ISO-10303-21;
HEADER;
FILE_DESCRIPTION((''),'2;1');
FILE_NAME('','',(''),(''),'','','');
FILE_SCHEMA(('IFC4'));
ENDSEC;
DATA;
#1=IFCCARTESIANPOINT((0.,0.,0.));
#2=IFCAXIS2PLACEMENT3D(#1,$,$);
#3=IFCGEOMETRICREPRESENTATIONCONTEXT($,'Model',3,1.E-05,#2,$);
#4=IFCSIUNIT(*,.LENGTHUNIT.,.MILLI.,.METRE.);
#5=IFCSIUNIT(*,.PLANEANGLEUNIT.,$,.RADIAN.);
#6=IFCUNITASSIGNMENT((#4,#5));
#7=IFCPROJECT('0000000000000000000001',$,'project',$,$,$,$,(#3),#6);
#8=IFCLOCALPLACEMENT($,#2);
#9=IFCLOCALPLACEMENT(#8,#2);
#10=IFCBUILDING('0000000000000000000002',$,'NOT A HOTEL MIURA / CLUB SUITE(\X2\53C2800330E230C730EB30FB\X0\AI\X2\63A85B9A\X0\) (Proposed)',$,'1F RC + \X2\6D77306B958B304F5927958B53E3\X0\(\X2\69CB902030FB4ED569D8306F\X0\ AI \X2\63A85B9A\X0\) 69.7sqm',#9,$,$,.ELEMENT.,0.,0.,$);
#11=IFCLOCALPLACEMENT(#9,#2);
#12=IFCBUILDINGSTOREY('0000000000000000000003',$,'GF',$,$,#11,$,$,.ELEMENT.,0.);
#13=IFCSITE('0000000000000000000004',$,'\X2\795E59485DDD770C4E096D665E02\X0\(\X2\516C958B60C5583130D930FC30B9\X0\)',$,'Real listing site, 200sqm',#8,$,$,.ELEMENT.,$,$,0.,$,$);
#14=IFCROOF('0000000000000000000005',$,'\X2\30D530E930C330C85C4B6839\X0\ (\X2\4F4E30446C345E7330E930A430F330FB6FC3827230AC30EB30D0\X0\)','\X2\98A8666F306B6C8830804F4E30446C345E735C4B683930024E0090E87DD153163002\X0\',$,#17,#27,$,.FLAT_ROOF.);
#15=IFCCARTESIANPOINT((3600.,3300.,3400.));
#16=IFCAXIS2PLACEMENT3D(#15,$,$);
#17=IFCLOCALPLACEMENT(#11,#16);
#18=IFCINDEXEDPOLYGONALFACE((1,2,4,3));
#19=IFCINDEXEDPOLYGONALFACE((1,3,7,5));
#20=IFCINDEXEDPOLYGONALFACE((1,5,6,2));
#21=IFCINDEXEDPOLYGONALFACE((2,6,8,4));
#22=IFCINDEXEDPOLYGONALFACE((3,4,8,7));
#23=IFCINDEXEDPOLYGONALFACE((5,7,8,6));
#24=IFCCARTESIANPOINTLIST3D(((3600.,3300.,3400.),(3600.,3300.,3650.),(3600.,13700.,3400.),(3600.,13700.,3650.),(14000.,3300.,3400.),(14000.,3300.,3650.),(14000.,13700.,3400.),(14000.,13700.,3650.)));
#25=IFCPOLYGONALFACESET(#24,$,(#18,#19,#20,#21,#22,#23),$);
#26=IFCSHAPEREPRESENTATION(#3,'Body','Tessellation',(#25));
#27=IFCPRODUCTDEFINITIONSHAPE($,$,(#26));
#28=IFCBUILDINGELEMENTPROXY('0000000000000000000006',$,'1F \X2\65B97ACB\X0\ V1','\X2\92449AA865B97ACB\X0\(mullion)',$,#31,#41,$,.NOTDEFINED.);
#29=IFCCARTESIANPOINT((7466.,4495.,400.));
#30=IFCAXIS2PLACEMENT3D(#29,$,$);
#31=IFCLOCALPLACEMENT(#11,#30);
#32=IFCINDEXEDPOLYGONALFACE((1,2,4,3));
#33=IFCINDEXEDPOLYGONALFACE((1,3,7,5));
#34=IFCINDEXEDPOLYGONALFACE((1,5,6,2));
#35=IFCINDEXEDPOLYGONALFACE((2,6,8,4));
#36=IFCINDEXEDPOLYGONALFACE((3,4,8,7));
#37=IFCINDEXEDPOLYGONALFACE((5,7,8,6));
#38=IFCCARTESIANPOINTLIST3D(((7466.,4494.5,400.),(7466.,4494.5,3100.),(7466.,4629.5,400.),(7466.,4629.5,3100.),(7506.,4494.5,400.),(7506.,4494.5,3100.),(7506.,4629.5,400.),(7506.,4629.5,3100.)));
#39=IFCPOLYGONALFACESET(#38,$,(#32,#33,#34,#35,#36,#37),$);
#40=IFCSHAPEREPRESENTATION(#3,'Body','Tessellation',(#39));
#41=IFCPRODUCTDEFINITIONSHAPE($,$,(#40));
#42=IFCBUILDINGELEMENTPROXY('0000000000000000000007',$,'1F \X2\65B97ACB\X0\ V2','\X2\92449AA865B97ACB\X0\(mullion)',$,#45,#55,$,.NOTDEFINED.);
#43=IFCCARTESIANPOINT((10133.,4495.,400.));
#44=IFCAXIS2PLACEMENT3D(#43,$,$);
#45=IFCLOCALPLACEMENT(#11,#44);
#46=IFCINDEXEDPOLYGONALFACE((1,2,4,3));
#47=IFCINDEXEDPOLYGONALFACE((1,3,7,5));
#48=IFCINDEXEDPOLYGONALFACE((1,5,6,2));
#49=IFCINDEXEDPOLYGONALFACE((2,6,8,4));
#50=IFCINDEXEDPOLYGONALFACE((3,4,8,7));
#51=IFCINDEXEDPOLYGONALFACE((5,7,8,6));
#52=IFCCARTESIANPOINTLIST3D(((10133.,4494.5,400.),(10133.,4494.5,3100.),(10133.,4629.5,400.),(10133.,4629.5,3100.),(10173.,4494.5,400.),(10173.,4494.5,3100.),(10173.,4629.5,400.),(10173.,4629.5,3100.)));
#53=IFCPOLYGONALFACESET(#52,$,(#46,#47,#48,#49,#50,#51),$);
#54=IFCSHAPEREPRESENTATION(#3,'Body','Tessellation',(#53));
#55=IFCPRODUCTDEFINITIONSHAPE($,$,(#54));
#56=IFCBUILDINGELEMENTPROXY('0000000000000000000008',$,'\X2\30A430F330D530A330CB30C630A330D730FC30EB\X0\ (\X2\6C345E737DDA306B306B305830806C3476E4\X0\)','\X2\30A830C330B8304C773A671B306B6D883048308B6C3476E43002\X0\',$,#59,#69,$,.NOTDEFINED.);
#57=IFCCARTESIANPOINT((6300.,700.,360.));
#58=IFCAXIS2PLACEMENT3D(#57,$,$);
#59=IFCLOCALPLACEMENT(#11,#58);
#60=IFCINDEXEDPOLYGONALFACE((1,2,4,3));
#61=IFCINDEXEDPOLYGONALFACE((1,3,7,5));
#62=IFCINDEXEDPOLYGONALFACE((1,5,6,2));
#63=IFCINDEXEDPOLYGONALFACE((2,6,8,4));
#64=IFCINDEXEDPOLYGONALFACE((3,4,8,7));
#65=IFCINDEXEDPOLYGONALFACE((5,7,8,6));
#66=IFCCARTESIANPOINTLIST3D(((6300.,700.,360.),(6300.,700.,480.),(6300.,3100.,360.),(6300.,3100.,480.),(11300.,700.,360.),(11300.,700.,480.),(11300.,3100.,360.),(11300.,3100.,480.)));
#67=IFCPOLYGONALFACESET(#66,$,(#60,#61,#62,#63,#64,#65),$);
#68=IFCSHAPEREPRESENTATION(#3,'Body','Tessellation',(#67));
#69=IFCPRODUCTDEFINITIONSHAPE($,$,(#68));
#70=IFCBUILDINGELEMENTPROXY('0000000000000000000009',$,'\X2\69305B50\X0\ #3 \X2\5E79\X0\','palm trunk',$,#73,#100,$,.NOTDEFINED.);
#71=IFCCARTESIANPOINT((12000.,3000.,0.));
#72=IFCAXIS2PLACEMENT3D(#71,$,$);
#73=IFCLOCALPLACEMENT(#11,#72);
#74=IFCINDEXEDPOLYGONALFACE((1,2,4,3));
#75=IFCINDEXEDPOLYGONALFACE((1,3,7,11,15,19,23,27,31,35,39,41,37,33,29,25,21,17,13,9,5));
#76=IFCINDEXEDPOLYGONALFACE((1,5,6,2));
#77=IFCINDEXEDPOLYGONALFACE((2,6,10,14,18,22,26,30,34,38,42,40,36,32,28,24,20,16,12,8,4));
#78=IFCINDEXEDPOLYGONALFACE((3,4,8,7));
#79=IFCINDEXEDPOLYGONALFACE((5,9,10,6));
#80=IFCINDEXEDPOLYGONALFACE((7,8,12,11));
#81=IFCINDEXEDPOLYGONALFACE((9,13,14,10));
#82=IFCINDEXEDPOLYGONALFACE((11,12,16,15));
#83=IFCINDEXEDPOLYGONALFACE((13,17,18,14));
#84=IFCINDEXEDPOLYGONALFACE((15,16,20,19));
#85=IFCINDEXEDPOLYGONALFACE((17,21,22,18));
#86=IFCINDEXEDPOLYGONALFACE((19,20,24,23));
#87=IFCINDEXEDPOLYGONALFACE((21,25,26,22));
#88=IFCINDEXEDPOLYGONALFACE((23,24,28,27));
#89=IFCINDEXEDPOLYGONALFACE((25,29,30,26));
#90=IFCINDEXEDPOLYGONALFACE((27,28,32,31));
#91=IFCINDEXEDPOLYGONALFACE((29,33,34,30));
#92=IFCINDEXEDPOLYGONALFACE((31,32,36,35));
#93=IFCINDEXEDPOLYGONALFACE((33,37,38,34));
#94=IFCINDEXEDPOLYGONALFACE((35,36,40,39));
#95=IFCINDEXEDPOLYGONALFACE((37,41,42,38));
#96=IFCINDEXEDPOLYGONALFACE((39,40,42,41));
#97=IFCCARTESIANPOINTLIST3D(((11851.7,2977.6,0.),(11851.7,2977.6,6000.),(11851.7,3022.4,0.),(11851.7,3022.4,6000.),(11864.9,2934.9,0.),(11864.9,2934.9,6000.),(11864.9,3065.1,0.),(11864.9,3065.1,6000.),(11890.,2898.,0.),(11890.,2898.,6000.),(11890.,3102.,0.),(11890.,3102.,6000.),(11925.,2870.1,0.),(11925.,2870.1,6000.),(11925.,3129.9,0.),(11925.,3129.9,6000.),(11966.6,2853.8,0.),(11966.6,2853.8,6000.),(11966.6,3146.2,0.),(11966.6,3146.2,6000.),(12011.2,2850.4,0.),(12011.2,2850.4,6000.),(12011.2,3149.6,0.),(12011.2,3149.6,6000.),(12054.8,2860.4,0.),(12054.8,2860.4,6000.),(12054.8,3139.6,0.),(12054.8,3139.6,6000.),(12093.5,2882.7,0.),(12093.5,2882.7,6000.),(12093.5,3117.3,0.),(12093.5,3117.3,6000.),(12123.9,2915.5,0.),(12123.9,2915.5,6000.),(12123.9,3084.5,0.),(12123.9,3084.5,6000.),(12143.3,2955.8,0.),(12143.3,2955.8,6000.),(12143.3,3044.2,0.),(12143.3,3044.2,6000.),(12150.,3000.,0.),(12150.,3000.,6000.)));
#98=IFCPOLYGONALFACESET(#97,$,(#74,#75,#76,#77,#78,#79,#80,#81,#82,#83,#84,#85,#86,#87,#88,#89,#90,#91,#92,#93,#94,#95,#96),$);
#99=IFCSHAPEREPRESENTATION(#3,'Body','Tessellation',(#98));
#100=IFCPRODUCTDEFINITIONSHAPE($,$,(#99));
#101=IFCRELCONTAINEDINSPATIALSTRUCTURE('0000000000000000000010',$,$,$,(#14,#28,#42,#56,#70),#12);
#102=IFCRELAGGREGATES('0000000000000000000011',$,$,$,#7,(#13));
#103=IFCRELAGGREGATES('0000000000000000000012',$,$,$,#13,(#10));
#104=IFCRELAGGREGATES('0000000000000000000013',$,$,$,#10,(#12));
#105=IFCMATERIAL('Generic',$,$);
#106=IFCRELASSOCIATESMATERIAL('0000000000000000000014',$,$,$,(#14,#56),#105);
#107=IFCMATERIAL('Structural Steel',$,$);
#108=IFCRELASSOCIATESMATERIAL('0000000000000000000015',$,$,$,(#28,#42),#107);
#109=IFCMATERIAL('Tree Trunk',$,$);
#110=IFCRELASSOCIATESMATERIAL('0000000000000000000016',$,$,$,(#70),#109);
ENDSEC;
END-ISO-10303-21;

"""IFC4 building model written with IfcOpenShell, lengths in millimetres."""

from ifc_helpers import new_model, si_unit, frame, frame_2d, origin, origin_2d, place, context, project, spatial, rectangle, circle, extrude, material, element, save


model = new_model("IFC4")

# Units and contexts
model_context = context("Model", 3, precision=1e-05, world=origin())
ifc_project = project(units=[si_unit("LENGTHUNIT", "METRE", prefix="MILLI"), si_unit("PLANEANGLEUNIT", "RADIAN")], contexts=[model_context])

# Site, building, storey
site_placement = place(None, origin())
site = spatial("IfcSite", under=ifc_project, at=site_placement, Name="神奈川県三浦市(公開情報ベース)", ObjectType="Real listing site, 200sqm", CompositionType="ELEMENT", RefElevation=0.0)
building_placement = place(site_placement, origin())
building = spatial("IfcBuilding", under=site, at=building_placement, Name="NOT A HOTEL MIURA / CLUB SUITE(参考モデル・AI推定) (Proposed)", ObjectType="1F RC + 海に開く大開口(構造・仕様は AI 推定) 69.7sqm", CompositionType="ELEMENT", ElevationOfRefHeight=0.0, ElevationOfTerrain=0.0)
storey_placement = place(building_placement, origin())
storey = spatial("IfcBuildingStorey", under=building, at=storey_placement, Name="GF", CompositionType="ELEMENT", Elevation=0.0)

# Shared definitions
ifc_material_1 = material(Name="Generic")

# Roof
roof_placement = place(storey_placement, frame((3600.0, 3300.0, 3400.0)))
element("IfcRoof", 1, at=roof_placement, inside=storey, material=ifc_material_1, Name="フラット屋根 (低い水平ライン・濃色ガルバ)", Description="風景に沈む低い水平屋根。一部緑化。", PredefinedType="FLAT_ROOF", context=model_context, shape_type="SweptSolid", body=[
    extrude(rectangle(XDim=10400.0, YDim=10400.0, at=frame_2d((5200.0, 5200.0))), frame((3600.0, 3300.0, 3400.0)), (0.0, 0.0, 1.0), 250.0),
])

# Building element proxies
ifc_material_2 = material(Name="Structural Steel")
proxy_1_placement = place(storey_placement, frame((7466.0, 4495.0, 400.0)))
element("IfcBuildingElementProxy", 2, at=proxy_1_placement, inside=storey, material=ifc_material_2, Name="1F 方立 V1", Description="鉄骨方立(mullion)", PredefinedType="NOTDEFINED", context=model_context, shape_type="SweptSolid", body=[
    extrude(rectangle(XDim=40.0, YDim=135.0, at=frame_2d((20.0, 67.0))), frame((7466.0, 4495.0, 400.0)), (0.0, 0.0, 1.0), 2700.0),
])
proxy_2_placement = place(storey_placement, frame((10133.0, 4495.0, 400.0)))
element("IfcBuildingElementProxy", 3, at=proxy_2_placement, inside=storey, material=ifc_material_2, Name="1F 方立 V2", Description="鉄骨方立(mullion)", PredefinedType="NOTDEFINED", context=model_context, shape_type="SweptSolid", body=[
    extrude(rectangle(XDim=40.0, YDim=135.0, at=frame_2d((20.0, 67.0))), frame((10133.0, 4495.0, 400.0)), (0.0, 0.0, 1.0), 2700.0),
])
proxy_3_placement = place(storey_placement, frame((6300.0, 700.0, 360.0)))
element("IfcBuildingElementProxy", 4, at=proxy_3_placement, inside=storey, material=ifc_material_1, Name="インフィニティプール (水平線ににじむ水盤)", Description="エッジが眺望に消える水盤。", PredefinedType="NOTDEFINED", context=model_context, shape_type="SweptSolid", body=[
    extrude(rectangle(XDim=5000.0, YDim=2400.0, at=frame_2d((2500.0, 1200.0))), frame((6300.0, 700.0, 360.0)), (0.0, 0.0, 1.0), 120.0),
])
ifc_material_3 = material(Name="Tree Trunk")
proxy_4_placement = place(storey_placement, frame((12000.0, 3000.0, 0.0)))
element("IfcBuildingElementProxy", 5, at=proxy_4_placement, inside=storey, material=ifc_material_3, Name="椰子 #3 幹", Description="palm trunk", PredefinedType="NOTDEFINED", context=model_context, shape_type="SweptSolid", body=[
    extrude(circle(Radius=150.0, at=origin_2d()), frame((12000.0, 3000.0, 0.0)), (0.0, 0.0, 1.0), 6000.0),
])

save(model, "model.ifc")
